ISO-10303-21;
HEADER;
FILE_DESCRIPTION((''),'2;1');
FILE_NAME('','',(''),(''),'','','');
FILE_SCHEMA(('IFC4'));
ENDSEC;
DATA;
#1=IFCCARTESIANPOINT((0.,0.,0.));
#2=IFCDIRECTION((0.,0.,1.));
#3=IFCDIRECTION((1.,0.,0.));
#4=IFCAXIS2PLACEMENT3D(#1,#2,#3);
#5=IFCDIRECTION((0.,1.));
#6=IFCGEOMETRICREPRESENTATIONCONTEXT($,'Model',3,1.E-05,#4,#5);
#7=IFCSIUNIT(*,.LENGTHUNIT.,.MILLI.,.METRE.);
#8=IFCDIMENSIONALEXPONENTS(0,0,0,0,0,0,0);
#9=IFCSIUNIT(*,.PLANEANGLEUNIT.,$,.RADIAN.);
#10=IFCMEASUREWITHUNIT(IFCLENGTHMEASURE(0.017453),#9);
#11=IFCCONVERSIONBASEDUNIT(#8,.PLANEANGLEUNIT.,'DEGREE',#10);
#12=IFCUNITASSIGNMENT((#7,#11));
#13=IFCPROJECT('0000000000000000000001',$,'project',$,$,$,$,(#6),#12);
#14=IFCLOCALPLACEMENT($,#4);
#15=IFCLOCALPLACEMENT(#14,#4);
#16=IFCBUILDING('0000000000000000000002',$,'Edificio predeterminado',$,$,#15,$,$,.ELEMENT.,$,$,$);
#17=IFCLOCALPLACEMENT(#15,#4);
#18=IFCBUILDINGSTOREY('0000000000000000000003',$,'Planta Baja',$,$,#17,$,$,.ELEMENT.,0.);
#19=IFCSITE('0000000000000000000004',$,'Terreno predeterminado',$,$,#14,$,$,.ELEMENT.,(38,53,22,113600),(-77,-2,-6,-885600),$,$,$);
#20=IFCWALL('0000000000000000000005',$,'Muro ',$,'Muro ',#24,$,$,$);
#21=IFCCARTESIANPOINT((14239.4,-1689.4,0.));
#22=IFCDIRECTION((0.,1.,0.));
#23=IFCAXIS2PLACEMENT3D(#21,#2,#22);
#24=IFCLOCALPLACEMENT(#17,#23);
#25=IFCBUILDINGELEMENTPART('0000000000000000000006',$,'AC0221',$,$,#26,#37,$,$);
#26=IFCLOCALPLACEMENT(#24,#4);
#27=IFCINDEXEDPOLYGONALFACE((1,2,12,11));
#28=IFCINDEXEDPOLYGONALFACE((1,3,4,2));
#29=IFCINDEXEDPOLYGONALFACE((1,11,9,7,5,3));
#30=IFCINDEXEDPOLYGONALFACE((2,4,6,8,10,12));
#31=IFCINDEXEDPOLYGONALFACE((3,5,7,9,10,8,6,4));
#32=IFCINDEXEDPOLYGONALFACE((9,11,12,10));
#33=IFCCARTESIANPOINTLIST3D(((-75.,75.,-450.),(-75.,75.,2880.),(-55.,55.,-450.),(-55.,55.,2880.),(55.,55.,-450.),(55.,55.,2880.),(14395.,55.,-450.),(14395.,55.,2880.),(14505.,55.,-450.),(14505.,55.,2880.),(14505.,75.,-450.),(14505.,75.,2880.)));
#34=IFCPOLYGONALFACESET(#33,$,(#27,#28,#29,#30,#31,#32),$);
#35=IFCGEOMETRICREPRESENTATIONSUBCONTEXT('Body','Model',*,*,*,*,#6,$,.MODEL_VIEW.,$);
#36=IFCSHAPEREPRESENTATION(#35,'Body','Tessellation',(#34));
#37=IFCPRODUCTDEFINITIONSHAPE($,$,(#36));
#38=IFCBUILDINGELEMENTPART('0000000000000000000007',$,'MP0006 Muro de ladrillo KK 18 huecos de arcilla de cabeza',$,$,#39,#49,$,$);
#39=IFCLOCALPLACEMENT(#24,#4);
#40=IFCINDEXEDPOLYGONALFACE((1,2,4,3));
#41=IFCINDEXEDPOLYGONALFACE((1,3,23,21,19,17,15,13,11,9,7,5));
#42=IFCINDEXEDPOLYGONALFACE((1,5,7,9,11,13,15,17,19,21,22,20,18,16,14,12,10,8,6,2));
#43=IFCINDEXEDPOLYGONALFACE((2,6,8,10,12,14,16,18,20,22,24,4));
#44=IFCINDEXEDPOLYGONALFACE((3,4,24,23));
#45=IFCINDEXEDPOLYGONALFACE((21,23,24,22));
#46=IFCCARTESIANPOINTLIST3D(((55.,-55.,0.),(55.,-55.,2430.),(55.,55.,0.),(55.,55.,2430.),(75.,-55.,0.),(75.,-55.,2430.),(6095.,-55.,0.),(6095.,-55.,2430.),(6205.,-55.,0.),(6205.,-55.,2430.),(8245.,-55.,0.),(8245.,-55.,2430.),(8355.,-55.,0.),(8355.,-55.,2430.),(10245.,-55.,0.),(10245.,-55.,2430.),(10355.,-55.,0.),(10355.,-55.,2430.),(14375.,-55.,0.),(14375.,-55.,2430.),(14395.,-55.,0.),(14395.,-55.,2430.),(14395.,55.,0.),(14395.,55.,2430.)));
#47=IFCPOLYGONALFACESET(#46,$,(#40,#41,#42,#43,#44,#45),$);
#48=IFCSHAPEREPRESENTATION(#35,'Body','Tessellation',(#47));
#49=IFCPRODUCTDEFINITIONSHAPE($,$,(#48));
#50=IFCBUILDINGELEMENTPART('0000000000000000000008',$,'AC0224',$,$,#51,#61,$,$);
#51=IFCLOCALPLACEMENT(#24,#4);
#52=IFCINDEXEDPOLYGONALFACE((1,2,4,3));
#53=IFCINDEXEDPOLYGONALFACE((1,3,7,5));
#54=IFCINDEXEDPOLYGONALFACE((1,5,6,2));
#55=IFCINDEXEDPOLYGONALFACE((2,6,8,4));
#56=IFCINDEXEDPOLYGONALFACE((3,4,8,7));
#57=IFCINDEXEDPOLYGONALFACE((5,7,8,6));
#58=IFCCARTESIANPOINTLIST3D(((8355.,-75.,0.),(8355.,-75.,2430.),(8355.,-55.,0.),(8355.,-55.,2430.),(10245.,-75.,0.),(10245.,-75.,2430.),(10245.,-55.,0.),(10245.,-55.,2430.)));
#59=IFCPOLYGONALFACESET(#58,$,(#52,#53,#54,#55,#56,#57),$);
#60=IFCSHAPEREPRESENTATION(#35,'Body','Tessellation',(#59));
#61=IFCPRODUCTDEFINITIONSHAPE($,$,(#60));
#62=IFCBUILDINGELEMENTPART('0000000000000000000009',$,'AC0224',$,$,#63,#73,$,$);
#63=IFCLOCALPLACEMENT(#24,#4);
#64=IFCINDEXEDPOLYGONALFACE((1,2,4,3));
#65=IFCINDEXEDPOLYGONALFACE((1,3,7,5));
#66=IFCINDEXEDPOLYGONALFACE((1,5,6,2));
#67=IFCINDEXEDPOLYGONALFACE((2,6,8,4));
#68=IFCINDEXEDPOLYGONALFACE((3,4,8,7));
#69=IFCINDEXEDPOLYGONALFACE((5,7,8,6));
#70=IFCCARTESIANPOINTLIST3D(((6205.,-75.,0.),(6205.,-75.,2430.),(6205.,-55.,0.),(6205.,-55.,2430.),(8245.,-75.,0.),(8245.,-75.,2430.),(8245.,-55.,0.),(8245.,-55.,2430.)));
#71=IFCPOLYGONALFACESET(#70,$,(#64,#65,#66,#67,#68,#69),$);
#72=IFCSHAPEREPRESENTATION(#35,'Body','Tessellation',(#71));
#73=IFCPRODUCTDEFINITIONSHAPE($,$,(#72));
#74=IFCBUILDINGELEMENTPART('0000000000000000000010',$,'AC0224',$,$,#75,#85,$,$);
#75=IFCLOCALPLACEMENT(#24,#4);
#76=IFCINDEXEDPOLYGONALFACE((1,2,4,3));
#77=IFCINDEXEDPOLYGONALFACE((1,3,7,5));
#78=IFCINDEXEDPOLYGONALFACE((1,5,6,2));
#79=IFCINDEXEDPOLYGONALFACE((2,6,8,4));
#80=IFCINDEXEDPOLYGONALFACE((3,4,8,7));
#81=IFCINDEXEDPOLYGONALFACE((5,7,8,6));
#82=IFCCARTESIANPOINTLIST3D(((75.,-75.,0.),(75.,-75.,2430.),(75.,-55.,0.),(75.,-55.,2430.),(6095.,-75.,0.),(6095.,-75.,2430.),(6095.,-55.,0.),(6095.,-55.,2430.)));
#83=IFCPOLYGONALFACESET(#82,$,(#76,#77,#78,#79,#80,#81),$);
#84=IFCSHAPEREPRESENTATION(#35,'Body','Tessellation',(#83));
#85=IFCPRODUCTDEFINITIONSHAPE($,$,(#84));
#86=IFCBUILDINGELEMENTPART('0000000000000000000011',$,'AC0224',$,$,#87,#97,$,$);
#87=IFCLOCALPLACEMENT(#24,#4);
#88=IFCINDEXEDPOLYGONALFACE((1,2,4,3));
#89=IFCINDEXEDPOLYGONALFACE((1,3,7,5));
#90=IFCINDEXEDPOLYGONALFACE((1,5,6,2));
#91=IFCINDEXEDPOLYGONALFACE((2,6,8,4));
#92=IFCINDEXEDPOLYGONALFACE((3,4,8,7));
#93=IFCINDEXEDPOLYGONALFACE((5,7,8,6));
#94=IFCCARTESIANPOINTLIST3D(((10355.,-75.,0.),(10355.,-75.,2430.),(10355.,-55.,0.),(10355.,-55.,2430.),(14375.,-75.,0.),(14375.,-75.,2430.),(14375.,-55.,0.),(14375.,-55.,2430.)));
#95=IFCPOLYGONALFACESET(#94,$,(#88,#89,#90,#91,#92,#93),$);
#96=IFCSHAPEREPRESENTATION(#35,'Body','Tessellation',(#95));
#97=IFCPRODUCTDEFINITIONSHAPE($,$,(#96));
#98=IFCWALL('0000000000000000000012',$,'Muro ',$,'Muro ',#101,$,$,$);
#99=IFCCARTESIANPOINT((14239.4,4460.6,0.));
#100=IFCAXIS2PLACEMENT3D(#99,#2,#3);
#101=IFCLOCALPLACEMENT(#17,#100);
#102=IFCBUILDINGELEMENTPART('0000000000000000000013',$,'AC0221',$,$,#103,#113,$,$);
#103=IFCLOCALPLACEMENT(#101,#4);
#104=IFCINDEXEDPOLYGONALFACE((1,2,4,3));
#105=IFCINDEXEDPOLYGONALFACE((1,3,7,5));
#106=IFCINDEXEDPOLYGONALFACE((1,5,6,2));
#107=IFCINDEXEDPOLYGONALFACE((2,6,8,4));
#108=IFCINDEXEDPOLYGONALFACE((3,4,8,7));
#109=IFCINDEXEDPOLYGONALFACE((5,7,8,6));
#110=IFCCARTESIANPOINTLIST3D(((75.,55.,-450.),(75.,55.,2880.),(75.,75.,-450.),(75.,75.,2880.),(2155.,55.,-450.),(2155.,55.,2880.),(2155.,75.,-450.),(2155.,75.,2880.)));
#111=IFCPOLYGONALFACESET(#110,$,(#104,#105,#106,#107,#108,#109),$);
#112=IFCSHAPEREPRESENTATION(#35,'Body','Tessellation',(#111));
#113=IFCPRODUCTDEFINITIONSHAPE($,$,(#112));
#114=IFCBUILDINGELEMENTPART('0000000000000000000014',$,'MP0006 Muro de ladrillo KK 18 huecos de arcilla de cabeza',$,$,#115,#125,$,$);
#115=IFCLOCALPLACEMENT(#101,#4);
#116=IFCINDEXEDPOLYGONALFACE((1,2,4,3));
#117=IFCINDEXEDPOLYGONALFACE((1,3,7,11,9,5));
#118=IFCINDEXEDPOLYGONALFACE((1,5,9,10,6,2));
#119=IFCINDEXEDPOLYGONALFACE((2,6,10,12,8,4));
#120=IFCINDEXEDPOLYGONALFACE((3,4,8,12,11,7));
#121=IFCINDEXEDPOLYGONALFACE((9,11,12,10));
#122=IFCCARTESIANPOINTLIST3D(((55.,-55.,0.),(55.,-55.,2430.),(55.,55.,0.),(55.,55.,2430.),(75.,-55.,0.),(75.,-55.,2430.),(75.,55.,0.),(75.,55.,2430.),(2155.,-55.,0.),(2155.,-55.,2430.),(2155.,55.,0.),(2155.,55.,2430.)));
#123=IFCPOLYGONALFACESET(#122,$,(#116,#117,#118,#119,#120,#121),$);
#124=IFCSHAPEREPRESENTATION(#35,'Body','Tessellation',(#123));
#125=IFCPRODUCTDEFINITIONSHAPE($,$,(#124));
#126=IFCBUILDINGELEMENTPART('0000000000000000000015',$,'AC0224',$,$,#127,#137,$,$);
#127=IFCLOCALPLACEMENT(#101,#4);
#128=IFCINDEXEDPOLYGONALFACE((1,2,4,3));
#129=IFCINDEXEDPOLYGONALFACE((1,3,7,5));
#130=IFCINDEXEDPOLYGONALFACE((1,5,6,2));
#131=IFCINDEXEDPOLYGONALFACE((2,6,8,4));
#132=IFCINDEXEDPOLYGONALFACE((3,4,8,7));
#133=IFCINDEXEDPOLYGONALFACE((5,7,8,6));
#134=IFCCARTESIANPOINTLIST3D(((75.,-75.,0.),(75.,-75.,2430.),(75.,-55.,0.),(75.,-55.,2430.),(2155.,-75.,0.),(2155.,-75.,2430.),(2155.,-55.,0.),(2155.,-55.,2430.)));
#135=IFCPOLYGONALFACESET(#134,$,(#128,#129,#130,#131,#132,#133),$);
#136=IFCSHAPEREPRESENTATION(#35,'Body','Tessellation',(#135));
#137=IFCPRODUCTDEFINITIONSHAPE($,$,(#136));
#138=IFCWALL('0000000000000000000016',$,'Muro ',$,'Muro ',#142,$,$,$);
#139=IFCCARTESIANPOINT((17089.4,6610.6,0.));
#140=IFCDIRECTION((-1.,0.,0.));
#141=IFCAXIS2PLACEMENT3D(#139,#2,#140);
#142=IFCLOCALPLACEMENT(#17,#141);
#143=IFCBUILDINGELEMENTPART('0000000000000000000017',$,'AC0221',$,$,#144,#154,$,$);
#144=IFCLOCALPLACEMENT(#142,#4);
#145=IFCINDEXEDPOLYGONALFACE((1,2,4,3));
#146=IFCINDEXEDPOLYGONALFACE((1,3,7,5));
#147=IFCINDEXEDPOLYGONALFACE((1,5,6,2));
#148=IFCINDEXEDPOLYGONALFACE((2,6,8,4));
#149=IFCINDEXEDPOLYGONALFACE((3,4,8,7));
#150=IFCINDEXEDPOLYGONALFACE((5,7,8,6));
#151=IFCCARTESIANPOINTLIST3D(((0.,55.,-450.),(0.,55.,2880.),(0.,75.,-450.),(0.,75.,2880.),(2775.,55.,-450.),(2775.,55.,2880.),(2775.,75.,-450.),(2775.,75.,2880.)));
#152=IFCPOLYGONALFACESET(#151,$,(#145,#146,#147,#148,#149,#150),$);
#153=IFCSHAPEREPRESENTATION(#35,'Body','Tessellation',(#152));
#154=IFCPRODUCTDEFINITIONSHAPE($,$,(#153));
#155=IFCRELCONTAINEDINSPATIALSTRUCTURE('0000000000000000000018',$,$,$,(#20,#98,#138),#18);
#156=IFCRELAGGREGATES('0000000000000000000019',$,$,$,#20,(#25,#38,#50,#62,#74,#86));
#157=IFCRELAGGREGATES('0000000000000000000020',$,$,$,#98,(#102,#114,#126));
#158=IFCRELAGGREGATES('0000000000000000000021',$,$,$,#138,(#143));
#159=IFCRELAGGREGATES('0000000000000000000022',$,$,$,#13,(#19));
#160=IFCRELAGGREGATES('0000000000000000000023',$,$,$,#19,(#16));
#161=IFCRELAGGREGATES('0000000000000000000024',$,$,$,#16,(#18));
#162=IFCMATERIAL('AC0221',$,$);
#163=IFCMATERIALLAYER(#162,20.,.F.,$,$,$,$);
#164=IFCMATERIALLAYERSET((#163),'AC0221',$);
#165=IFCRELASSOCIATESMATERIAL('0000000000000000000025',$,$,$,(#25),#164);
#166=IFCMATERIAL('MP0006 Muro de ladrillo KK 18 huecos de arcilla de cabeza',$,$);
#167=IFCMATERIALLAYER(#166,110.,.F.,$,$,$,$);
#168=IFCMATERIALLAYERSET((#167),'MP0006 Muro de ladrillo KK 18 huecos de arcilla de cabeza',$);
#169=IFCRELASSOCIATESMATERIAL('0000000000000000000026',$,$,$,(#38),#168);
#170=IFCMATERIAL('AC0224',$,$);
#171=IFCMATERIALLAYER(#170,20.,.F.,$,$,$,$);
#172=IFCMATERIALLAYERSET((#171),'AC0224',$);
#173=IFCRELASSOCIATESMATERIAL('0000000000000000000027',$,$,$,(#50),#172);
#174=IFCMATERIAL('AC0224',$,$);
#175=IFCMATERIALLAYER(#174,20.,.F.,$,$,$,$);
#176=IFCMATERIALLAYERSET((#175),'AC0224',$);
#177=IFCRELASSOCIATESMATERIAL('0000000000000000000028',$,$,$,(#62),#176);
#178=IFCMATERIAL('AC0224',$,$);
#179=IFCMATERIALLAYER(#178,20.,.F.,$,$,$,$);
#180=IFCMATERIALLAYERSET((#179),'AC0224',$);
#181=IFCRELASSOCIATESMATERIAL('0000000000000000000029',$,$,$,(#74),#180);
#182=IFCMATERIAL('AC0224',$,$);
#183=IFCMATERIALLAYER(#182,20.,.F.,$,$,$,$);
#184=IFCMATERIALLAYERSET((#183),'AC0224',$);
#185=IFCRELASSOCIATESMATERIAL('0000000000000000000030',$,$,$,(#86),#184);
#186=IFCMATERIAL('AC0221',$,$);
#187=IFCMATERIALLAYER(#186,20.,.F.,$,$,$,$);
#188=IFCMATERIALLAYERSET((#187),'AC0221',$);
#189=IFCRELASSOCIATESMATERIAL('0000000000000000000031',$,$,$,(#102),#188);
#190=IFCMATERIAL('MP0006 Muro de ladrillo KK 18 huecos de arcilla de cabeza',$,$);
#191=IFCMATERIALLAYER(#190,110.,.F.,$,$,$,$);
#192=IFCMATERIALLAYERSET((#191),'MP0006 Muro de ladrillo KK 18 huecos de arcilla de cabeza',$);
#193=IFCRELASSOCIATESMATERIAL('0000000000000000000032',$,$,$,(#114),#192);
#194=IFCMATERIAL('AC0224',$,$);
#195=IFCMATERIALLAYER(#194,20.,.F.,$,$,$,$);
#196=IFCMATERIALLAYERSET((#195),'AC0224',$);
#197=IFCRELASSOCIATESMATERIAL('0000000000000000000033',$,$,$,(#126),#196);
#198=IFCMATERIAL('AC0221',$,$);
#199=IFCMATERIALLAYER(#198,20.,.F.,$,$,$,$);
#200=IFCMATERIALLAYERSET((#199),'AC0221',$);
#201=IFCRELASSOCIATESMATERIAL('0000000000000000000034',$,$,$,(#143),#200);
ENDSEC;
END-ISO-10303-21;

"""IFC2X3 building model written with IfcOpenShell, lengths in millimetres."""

from ifc_helpers import new_model, entity, si_unit, converted_unit, direction, frame, origin_with_axes, place, context, subcontext, project, spatial, polyline, outline, extrude, material, layer, layer_set, layer_usage, element, aggregate, save


model = new_model("IFC2X3")

# Units and contexts
model_context = context("Model", 3, precision=1e-05, world=origin_with_axes(), true_north=direction((0.0, 1.0)))
body_context = subcontext(model_context, "Body", "Model", "MODEL_VIEW")
ifc_project = project(units=[si_unit("LENGTHUNIT", "METRE", prefix="MILLI"), converted_unit("PLANEANGLEUNIT", "DEGREE", entity("IfcLengthMeasure", 0.017453), si_unit("PLANEANGLEUNIT", "RADIAN"), dimensions=[0, 0, 0, 0, 0, 0, 0])], contexts=[model_context])

# Site, building, storey
site_placement = place(None, origin_with_axes())
site = spatial("IfcSite", under=ifc_project, at=site_placement, Name="Terreno predeterminado", CompositionType="ELEMENT", RefLatitude=(38, 53, 22, 113600), RefLongitude=(-77, -2, -6, -885600))
building_placement = place(site_placement, origin_with_axes())
building = spatial("IfcBuilding", under=site, at=building_placement, Name="Edificio predeterminado", CompositionType="ELEMENT")
storey_placement = place(building_placement, origin_with_axes())
storey = spatial("IfcBuildingStorey", under=building, at=storey_placement, Name="Planta Baja", CompositionType="ELEMENT", Elevation=0.0)

# Walls, building element parts
wall_1_placement = place(storey_placement, frame((14239.4, -1689.4, 0.0), z_axis=(0.0, 0.0, 1.0), x_axis=(0.0, 1.0, 0.0)))
wall_1 = element("IfcWall", 1, at=wall_1_placement, inside=storey, Name="Muro ", ObjectType="Muro ")
ifc_material_1 = material(Name="AC0221")
ifc_layer_1 = layer(ifc_material_1, 20.0, ventilated=False)
ifc_layer_set_1 = layer_set([ifc_layer_1], Name="AC0221")
ifc_layer_usage_1 = layer_usage(ifc_layer_set_1, "AXIS2", "NEGATIVE", -75.0)
building_element_part_1_placement = place(wall_1_placement, origin_with_axes())
building_element_part_1 = element("IfcBuildingElementPart", 2, at=building_element_part_1_placement, material=ifc_layer_usage_1, Name="AC0221", context=body_context, shape_type="SweptSolid", body=[
    extrude(outline(polyline([(14505.0, 75.0), (14505.0, 55.0), (14395.0, 55.0), (55.0, 55.0), (-55.0, 55.0), (-75.0, 75.0), (14505.0, 75.0)])), frame((0.0, 0.0, -450.0), z_axis=(0.0, 0.0, 1.0), x_axis=(1.0, 0.0, 0.0)), (0.0, 0.0, 1.0), 3330.0),
])
ifc_material_2 = material(Name="MP0006 Muro de ladrillo KK 18 huecos de arcilla de cabeza")
ifc_layer_2 = layer(ifc_material_2, 110.0, ventilated=False)
ifc_layer_set_2 = layer_set([ifc_layer_2], Name="MP0006 Muro de ladrillo KK 18 huecos de arcilla de cabeza")
ifc_layer_usage_2 = layer_usage(ifc_layer_set_2, "AXIS2", "NEGATIVE", -55.0)
building_element_part_2_placement = place(wall_1_placement, origin_with_axes())
building_element_part_2 = element("IfcBuildingElementPart", 3, at=building_element_part_2_placement, material=ifc_layer_usage_2, Name="MP0006 Muro de ladrillo KK 18 huecos de arcilla de cabeza", context=body_context, shape_type="SweptSolid", body=[
    extrude(outline(polyline([(14395.0, 55.0), (14395.0, -55.0), (14375.0, -55.0), (10355.0, -55.0), (10245.0, -55.0), (8355.0, -55.0), (8245.0, -55.0), (6205.0, -55.0), (6095.0, -55.0), (75.0, -55.0), (55.0, -55.0), (55.0, 55.0), (14395.0, 55.0)])), origin_with_axes(), (0.0, 0.0, 1.0), 2430.0),
])
ifc_material_3 = material(Name="AC0224")
ifc_layer_3 = layer(ifc_material_3, 20.0, ventilated=False)
ifc_layer_set_3 = layer_set([ifc_layer_3], Name="AC0224")
ifc_layer_usage_3 = layer_usage(ifc_layer_set_3, "AXIS2", "NEGATIVE", 55.0)
building_element_part_3_placement = place(wall_1_placement, origin_with_axes())
building_element_part_3 = element("IfcBuildingElementPart", 4, at=building_element_part_3_placement, material=ifc_layer_usage_3, Name="AC0224", context=body_context, shape_type="SweptSolid", body=[
    extrude(outline(polyline([(8355.0, -55.0), (10245.0, -55.0), (10245.0, -75.0), (8355.0, -75.0), (8355.0, -55.0)])), origin_with_axes(), (0.0, 0.0, 1.0), 2430.0),
])
ifc_material_4 = material(Name="AC0224")
ifc_layer_4 = layer(ifc_material_4, 20.0, ventilated=False)
ifc_layer_set_4 = layer_set([ifc_layer_4], Name="AC0224")
ifc_layer_usage_4 = layer_usage(ifc_layer_set_4, "AXIS2", "NEGATIVE", 55.0)
building_element_part_4_placement = place(wall_1_placement, origin_with_axes())
building_element_part_4 = element("IfcBuildingElementPart", 5, at=building_element_part_4_placement, material=ifc_layer_usage_4, Name="AC0224", context=body_context, shape_type="SweptSolid", body=[
    extrude(outline(polyline([(8245.0, -55.0), (8245.0, -75.0), (6205.0, -75.0), (6205.0, -55.0), (8245.0, -55.0)])), origin_with_axes(), (0.0, 0.0, 1.0), 2430.0),
])
ifc_material_5 = material(Name="AC0224")
ifc_layer_5 = layer(ifc_material_5, 20.0, ventilated=False)
ifc_layer_set_5 = layer_set([ifc_layer_5], Name="AC0224")
ifc_layer_usage_5 = layer_usage(ifc_layer_set_5, "AXIS2", "NEGATIVE", 55.0)
building_element_part_5_placement = place(wall_1_placement, origin_with_axes())
building_element_part_5 = element("IfcBuildingElementPart", 6, at=building_element_part_5_placement, material=ifc_layer_usage_5, Name="AC0224", context=body_context, shape_type="SweptSolid", body=[
    extrude(outline(polyline([(6095.0, -55.0), (6095.0, -75.0), (75.0, -75.0), (75.0, -55.0), (6095.0, -55.0)])), origin_with_axes(), (0.0, 0.0, 1.0), 2430.0),
])
ifc_material_6 = material(Name="AC0224")
ifc_layer_6 = layer(ifc_material_6, 20.0, ventilated=False)
ifc_layer_set_6 = layer_set([ifc_layer_6], Name="AC0224")
ifc_layer_usage_6 = layer_usage(ifc_layer_set_6, "AXIS2", "NEGATIVE", 55.0)
building_element_part_6_placement = place(wall_1_placement, origin_with_axes())
building_element_part_6 = element("IfcBuildingElementPart", 7, at=building_element_part_6_placement, material=ifc_layer_usage_6, Name="AC0224", context=body_context, shape_type="SweptSolid", body=[
    extrude(outline(polyline([(14375.0, -55.0), (14375.0, -75.0), (10355.0, -75.0), (10355.0, -55.0), (14375.0, -55.0)])), origin_with_axes(), (0.0, 0.0, 1.0), 2430.0),
])
aggregate(wall_1, [building_element_part_1, building_element_part_2, building_element_part_3, building_element_part_4, building_element_part_5, building_element_part_6])
wall_2_placement = place(storey_placement, frame((14239.4, 4460.6, 0.0), z_axis=(0.0, 0.0, 1.0), x_axis=(1.0, 0.0, 0.0)))
wall_2 = element("IfcWall", 8, at=wall_2_placement, inside=storey, Name="Muro ", ObjectType="Muro ")
ifc_material_7 = material(Name="AC0221")
ifc_layer_7 = layer(ifc_material_7, 20.0, ventilated=False)
ifc_layer_set_7 = layer_set([ifc_layer_7], Name="AC0221")
ifc_layer_usage_7 = layer_usage(ifc_layer_set_7, "AXIS2", "NEGATIVE", -75.0)
building_element_part_7_placement = place(wall_2_placement, origin_with_axes())
building_element_part_7 = element("IfcBuildingElementPart", 9, at=building_element_part_7_placement, material=ifc_layer_usage_7, Name="AC0221", context=body_context, shape_type="SweptSolid", body=[
    extrude(outline(polyline([(2155.0, 75.0), (2155.0, 55.0), (75.0, 55.0), (75.0, 75.0), (2155.0, 75.0)])), frame((0.0, 0.0, -450.0), z_axis=(0.0, 0.0, 1.0), x_axis=(1.0, 0.0, 0.0)), (0.0, 0.0, 1.0), 3330.0),
])
ifc_material_8 = material(Name="MP0006 Muro de ladrillo KK 18 huecos de arcilla de cabeza")
ifc_layer_8 = layer(ifc_material_8, 110.0, ventilated=False)
ifc_layer_set_8 = layer_set([ifc_layer_8], Name="MP0006 Muro de ladrillo KK 18 huecos de arcilla de cabeza")
ifc_layer_usage_8 = layer_usage(ifc_layer_set_8, "AXIS2", "NEGATIVE", -55.0)
building_element_part_8_placement = place(wall_2_placement, origin_with_axes())
building_element_part_8 = element("IfcBuildingElementPart", 10, at=building_element_part_8_placement, material=ifc_layer_usage_8, Name="MP0006 Muro de ladrillo KK 18 huecos de arcilla de cabeza", context=body_context, shape_type="SweptSolid", body=[
    extrude(outline(polyline([(2155.0, 55.0), (2155.0, -55.0), (75.0, -55.0), (55.0, -55.0), (55.0, 55.0), (75.0, 55.0), (2155.0, 55.0)])), origin_with_axes(), (0.0, 0.0, 1.0), 2430.0),
])
ifc_material_9 = material(Name="AC0224")
ifc_layer_9 = layer(ifc_material_9, 20.0, ventilated=False)
ifc_layer_set_9 = layer_set([ifc_layer_9], Name="AC0224")
ifc_layer_usage_9 = layer_usage(ifc_layer_set_9, "AXIS2", "NEGATIVE", 55.0)
building_element_part_9_placement = place(wall_2_placement, origin_with_axes())
building_element_part_9 = element("IfcBuildingElementPart", 11, at=building_element_part_9_placement, material=ifc_layer_usage_9, Name="AC0224", context=body_context, shape_type="SweptSolid", body=[
    extrude(outline(polyline([(2155.0, -55.0), (2155.0, -75.0), (75.0, -75.0), (75.0, -55.0), (2155.0, -55.0)])), origin_with_axes(), (0.0, 0.0, 1.0), 2430.0),
])
aggregate(wall_2, [building_element_part_7, building_element_part_8, building_element_part_9])

# Wall, building element part
wall_3_placement = place(storey_placement, frame((17089.4, 6610.6, 0.0), z_axis=(0.0, 0.0, 1.0), x_axis=(-1.0, 0.0, 0.0)))
wall_3 = element("IfcWall", 12, at=wall_3_placement, inside=storey, Name="Muro ", ObjectType="Muro ")
ifc_material_10 = material(Name="AC0221")
ifc_layer_10 = layer(ifc_material_10, 20.0, ventilated=False)
ifc_layer_set_10 = layer_set([ifc_layer_10], Name="AC0221")
ifc_layer_usage_10 = layer_usage(ifc_layer_set_10, "AXIS2", "NEGATIVE", -75.0)
building_element_part_10_placement = place(wall_3_placement, origin_with_axes())
building_element_part_10 = element("IfcBuildingElementPart", 13, at=building_element_part_10_placement, material=ifc_layer_usage_10, Name="AC0221", context=body_context, shape_type="SweptSolid", body=[
    extrude(outline(polyline([(0.0, 75.0), (2775.0, 75.0), (2775.0, 55.0), (0.0, 55.0), (0.0, 75.0)])), frame((0.0, 0.0, -450.0), z_axis=(0.0, 0.0, 1.0), x_axis=(1.0, 0.0, 0.0)), (0.0, 0.0, 1.0), 3330.0),
])
aggregate(wall_3, [building_element_part_10])

save(model, "model.ifc")
